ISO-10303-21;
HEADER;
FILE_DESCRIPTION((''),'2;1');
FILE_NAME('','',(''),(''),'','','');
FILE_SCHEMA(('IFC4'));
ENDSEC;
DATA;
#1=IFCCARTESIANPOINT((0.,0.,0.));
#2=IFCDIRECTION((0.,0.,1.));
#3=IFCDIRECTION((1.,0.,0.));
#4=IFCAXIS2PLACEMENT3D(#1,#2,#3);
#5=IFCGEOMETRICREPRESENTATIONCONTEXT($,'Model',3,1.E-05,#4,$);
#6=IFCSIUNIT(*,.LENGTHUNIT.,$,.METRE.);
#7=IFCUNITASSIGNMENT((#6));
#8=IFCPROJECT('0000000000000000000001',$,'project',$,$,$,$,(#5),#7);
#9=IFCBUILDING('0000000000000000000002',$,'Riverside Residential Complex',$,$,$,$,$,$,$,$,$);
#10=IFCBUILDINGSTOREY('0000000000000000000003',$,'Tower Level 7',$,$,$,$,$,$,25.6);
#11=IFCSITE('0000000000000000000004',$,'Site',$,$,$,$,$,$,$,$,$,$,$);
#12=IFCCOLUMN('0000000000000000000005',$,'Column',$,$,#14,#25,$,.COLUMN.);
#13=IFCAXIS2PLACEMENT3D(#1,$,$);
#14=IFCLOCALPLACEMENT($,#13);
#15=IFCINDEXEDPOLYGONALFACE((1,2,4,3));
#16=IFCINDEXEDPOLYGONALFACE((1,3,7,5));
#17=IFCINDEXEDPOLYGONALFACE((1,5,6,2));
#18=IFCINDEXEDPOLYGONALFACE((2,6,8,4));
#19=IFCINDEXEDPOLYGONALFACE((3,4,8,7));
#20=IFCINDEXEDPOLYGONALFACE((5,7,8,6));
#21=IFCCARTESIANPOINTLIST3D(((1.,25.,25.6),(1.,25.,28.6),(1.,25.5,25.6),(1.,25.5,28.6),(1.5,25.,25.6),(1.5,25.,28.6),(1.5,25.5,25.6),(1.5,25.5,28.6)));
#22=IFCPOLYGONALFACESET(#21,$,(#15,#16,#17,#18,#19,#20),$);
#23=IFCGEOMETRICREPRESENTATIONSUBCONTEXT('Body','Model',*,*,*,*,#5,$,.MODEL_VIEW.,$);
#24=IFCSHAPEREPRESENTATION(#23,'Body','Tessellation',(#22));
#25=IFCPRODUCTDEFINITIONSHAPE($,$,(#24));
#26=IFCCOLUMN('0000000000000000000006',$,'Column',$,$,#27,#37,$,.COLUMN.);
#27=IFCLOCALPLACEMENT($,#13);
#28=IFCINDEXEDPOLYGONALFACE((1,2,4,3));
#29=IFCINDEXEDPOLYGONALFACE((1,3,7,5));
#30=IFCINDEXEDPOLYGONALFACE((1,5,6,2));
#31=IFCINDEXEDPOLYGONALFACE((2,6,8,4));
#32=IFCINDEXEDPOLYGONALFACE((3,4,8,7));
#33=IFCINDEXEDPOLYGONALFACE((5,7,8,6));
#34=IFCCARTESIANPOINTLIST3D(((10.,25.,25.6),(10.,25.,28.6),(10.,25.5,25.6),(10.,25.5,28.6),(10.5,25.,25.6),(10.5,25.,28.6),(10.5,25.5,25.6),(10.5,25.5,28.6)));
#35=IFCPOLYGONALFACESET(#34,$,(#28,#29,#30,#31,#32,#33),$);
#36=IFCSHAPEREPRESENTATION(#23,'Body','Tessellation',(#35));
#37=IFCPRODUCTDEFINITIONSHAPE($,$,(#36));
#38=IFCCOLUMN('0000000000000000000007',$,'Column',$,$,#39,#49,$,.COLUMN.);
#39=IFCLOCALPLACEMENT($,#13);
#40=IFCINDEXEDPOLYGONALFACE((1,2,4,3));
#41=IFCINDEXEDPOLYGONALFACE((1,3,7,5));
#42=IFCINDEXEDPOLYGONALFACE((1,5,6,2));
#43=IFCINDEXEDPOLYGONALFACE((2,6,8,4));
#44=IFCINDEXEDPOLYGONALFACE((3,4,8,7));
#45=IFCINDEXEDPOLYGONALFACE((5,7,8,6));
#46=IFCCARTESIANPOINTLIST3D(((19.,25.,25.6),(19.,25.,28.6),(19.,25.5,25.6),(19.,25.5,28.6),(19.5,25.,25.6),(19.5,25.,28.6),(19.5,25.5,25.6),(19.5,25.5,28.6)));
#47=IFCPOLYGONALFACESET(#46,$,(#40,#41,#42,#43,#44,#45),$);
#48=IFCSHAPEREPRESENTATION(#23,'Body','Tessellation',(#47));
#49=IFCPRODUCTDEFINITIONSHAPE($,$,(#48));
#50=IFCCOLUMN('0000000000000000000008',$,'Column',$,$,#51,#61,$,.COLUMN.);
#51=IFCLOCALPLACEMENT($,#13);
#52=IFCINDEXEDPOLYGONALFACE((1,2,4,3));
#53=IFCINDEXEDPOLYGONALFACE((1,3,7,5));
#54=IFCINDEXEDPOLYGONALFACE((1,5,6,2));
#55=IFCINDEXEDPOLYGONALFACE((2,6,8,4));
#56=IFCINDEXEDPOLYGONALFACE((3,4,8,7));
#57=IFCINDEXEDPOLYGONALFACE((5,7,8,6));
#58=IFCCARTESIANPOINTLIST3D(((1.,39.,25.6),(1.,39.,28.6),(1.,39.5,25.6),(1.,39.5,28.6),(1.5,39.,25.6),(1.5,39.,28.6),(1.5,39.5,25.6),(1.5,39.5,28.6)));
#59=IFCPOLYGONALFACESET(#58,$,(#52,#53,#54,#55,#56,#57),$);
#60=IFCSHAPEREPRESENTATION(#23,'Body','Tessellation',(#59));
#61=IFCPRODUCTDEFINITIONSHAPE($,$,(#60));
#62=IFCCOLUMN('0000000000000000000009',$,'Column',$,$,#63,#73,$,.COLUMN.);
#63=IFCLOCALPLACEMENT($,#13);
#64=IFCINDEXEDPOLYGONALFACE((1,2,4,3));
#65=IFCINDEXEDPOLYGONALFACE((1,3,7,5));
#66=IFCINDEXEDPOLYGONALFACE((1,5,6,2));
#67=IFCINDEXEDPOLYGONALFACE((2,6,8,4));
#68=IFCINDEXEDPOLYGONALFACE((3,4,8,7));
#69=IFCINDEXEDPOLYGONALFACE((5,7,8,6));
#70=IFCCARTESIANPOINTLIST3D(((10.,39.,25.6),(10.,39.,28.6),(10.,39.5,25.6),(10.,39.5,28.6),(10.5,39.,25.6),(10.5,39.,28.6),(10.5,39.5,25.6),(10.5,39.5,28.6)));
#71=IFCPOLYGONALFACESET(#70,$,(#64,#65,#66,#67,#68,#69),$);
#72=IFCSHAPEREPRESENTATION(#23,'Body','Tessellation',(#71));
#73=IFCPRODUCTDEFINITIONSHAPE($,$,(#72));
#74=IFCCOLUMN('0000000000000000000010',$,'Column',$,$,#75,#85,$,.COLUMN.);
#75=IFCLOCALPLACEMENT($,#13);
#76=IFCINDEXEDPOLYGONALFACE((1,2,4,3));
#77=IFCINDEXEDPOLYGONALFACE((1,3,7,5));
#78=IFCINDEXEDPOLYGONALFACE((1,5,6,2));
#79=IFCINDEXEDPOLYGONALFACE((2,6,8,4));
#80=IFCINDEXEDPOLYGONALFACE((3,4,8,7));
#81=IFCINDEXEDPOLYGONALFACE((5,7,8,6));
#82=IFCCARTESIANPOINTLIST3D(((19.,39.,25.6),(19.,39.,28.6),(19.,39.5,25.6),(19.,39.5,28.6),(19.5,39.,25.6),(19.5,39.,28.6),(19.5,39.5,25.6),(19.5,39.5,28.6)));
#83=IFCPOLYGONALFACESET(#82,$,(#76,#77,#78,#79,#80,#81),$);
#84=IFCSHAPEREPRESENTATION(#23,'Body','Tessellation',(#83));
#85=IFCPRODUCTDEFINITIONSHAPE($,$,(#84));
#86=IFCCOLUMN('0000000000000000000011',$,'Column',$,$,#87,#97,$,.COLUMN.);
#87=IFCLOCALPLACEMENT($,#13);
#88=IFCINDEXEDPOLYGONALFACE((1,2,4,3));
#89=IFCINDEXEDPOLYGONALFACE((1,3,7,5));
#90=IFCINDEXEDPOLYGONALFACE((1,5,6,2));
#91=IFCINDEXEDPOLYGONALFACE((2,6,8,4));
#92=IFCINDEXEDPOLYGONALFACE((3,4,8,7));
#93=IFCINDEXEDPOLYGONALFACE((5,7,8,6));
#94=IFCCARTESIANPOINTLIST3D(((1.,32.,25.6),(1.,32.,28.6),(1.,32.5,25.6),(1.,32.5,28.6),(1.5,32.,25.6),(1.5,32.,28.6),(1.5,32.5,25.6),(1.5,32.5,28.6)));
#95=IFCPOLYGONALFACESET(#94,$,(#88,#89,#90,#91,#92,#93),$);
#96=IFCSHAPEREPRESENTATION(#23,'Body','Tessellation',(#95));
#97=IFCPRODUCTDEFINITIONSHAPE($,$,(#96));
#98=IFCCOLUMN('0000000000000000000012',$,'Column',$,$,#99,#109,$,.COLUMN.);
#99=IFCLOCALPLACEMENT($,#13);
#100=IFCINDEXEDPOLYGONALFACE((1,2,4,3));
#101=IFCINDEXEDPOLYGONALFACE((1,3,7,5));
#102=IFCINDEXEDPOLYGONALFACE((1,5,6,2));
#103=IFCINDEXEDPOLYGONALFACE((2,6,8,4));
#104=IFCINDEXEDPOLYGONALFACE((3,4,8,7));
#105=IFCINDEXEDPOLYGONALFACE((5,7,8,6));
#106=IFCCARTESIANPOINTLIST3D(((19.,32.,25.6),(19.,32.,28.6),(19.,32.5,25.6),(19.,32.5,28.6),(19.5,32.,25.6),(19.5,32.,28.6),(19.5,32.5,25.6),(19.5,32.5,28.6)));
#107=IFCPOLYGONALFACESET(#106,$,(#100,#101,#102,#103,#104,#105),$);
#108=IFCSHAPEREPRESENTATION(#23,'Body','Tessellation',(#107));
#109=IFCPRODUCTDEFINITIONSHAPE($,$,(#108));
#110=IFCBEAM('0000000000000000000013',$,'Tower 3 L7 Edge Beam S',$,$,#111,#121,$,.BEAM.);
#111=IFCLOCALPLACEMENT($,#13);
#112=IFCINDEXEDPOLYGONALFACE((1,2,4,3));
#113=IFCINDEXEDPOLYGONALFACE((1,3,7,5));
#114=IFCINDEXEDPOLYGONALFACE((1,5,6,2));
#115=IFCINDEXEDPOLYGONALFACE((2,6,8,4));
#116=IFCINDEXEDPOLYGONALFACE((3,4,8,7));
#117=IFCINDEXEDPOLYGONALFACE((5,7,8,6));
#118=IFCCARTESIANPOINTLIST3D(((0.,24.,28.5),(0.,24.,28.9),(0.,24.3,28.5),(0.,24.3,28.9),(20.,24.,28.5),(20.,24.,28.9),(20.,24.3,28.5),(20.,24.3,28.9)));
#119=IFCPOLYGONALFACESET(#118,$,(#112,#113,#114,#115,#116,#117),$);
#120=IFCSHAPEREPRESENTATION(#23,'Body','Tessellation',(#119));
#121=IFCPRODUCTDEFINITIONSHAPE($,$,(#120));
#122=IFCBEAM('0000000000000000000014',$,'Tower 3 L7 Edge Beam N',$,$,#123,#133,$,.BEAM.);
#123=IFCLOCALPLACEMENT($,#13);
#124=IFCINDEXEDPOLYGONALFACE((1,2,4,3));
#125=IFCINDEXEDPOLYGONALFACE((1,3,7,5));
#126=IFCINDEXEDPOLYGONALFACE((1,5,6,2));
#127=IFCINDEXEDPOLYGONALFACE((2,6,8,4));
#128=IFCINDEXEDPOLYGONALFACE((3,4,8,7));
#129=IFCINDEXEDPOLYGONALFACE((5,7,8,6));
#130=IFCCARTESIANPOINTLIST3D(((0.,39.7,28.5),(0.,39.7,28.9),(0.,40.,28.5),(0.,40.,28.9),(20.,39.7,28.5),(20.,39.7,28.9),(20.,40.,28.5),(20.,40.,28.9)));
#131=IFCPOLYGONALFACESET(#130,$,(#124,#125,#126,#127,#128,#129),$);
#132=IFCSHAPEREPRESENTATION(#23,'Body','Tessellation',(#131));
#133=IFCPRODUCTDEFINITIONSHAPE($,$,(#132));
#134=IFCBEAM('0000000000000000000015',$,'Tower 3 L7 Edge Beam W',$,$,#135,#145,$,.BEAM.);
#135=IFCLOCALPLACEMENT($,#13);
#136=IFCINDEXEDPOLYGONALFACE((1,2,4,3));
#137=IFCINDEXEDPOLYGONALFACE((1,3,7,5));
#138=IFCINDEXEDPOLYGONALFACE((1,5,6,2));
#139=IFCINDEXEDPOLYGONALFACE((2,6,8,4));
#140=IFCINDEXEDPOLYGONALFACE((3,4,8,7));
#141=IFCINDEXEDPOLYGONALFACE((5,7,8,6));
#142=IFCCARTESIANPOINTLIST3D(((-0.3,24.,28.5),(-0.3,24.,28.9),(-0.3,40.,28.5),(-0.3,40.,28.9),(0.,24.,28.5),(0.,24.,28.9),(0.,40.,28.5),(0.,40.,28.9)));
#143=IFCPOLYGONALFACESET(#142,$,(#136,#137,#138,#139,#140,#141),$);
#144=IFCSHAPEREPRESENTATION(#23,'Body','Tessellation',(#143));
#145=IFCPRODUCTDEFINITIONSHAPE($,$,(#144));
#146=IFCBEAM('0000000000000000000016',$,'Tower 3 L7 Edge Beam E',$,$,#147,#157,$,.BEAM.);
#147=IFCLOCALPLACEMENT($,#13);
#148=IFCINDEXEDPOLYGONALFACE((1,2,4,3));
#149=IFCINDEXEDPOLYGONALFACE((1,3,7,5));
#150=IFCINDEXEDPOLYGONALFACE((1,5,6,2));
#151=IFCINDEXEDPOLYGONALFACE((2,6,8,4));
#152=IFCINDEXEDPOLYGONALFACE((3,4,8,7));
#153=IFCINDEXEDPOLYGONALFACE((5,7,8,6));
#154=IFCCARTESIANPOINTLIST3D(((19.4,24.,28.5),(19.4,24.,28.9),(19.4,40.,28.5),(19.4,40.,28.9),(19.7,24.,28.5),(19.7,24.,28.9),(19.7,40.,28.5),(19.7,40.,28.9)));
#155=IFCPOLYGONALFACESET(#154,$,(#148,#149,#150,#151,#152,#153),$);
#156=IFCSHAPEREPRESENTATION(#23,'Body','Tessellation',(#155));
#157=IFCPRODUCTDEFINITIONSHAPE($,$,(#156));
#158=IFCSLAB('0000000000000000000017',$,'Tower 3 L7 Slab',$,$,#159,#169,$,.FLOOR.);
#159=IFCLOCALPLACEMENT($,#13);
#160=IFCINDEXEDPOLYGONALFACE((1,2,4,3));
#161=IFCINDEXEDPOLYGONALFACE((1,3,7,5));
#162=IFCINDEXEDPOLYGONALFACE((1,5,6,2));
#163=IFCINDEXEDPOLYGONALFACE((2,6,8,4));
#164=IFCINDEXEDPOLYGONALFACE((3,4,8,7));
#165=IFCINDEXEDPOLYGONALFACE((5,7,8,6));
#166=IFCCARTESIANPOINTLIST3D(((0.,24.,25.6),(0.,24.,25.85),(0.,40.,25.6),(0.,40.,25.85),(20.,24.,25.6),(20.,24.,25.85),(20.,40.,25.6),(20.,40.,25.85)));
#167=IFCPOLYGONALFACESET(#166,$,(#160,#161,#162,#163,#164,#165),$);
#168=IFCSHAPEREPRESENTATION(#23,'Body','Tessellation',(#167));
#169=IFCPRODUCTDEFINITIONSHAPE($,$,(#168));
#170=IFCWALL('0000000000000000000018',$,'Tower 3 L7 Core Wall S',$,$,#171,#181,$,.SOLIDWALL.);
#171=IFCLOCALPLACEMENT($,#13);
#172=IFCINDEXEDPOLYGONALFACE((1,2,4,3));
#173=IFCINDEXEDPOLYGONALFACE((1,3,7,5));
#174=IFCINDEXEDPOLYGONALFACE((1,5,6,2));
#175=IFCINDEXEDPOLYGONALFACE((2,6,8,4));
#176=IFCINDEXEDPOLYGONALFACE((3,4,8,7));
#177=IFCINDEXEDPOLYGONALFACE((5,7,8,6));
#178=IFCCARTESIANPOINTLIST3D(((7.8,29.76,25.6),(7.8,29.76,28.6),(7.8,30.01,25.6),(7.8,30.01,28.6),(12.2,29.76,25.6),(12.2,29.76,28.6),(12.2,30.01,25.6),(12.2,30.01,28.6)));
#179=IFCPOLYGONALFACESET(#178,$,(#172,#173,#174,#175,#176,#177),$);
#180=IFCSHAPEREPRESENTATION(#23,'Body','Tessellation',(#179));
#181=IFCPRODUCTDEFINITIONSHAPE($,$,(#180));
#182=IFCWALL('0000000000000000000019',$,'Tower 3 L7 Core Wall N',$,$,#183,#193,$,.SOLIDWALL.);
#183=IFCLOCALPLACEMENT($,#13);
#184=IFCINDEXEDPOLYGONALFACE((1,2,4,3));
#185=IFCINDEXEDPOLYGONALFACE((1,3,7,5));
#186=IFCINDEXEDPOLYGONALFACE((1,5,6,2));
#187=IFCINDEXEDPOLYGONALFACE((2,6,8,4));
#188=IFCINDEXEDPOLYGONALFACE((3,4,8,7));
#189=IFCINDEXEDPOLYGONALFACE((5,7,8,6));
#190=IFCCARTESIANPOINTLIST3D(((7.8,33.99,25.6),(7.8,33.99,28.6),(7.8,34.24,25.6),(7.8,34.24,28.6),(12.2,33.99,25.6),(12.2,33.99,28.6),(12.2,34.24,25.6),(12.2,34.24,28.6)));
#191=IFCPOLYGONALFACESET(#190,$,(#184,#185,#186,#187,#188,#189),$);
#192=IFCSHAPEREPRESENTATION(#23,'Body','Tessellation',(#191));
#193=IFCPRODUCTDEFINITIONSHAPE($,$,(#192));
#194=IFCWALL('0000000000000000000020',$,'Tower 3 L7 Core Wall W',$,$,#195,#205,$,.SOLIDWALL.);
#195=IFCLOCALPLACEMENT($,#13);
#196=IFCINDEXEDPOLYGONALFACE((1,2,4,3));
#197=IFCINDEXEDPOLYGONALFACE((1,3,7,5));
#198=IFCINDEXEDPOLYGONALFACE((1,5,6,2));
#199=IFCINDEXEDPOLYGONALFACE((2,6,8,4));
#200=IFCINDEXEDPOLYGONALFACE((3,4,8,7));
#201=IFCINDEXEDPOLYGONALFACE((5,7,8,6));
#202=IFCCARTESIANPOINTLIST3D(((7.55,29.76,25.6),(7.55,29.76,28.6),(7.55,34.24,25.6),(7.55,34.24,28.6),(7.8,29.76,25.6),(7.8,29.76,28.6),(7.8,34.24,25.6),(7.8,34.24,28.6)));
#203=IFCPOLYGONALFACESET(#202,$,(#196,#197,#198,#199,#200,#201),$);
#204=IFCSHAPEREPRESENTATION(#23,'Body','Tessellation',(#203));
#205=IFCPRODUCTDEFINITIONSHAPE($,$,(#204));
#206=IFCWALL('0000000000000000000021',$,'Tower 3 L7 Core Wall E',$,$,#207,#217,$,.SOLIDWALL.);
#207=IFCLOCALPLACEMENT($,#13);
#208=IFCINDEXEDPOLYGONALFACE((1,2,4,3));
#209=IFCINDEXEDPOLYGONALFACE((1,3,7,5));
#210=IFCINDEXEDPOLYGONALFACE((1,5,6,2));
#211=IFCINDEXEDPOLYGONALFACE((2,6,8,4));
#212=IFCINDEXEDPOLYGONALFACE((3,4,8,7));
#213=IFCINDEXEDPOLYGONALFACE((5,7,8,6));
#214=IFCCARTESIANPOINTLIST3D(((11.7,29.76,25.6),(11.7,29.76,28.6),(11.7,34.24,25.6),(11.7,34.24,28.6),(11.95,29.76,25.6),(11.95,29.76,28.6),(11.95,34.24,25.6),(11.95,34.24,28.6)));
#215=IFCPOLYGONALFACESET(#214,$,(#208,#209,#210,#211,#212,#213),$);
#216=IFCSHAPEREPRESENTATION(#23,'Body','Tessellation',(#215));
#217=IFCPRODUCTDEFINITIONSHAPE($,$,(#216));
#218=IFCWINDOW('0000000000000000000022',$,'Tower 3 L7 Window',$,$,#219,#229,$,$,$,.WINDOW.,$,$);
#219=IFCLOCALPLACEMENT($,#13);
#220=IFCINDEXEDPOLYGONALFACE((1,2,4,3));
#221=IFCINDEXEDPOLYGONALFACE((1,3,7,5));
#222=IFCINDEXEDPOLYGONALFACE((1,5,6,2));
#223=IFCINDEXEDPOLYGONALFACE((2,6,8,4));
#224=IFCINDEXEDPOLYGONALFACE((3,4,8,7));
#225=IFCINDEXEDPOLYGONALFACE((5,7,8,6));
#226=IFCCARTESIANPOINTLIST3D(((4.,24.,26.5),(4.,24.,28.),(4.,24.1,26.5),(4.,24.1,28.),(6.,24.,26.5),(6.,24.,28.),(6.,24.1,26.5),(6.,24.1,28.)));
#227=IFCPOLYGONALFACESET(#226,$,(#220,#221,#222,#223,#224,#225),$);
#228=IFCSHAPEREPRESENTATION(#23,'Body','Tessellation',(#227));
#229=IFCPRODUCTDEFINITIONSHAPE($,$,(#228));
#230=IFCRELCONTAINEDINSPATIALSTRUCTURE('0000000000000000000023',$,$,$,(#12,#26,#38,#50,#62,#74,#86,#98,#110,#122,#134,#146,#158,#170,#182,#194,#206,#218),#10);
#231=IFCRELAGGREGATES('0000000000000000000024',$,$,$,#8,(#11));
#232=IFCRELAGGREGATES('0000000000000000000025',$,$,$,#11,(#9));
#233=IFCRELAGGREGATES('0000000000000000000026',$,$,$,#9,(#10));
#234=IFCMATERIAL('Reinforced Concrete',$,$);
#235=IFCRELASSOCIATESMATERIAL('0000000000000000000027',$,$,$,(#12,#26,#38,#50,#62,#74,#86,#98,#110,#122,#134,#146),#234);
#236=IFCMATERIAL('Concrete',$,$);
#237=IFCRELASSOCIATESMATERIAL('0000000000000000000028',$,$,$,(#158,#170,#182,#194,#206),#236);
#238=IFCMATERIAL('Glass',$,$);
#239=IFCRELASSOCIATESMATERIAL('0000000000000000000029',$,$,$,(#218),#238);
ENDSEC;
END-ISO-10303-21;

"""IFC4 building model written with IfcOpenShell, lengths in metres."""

from ifc_helpers import new_model, si_unit, frame, origin_with_axes, place, context, subcontext, project, spatial, line, indexed_curve, outline, extrude, material, element, save


model = new_model("IFC4")

# Units and contexts
model_context = context("Model", 3, precision=1e-05, world=origin_with_axes())
body_context = subcontext(model_context, "Body", "Model", "MODEL_VIEW")
ifc_project = project(units=[si_unit("LENGTHUNIT", "METRE")], contexts=[model_context])

# Site, building, storey
site = spatial("IfcSite", under=ifc_project, Name="Site")
building = spatial("IfcBuilding", under=site, Name="Riverside Residential Complex")
storey = spatial("IfcBuildingStorey", under=building, Name="Tower Level 7", Elevation=25.6)

# Columns
ifc_material_1 = material(Name="Reinforced Concrete")
for number, where, z_axis, x_axis, name in (
    (1, (1.0, 25.0, 25.6), (0.0, 0.0, 1.0), (1.0, 0.0, 0.0), "Column"),
    (2, (10.0, 25.0, 25.6), (0.0, 0.0, 1.0), (1.0, 0.0, 0.0), "Column"),
    (3, (19.0, 25.0, 25.6), (0.0, 0.0, 1.0), (1.0, 0.0, 0.0), "Column"),
    (4, (1.0, 39.0, 25.6), (0.0, 0.0, 1.0), (1.0, 0.0, 0.0), "Column"),
    (5, (10.0, 39.0, 25.6), (0.0, 0.0, 1.0), (1.0, 0.0, 0.0), "Column"),
    (6, (19.0, 39.0, 25.6), (0.0, 0.0, 1.0), (1.0, 0.0, 0.0), "Column"),
    (7, (1.0, 32.0, 25.6), (0.0, 0.0, 1.0), (1.0, 0.0, 0.0), "Column"),
    (8, (19.0, 32.0, 25.6), (0.0, 0.0, 1.0), (1.0, 0.0, 0.0), "Column"),
):
    element("IfcColumn", number, at=place(None, frame(where, z_axis=z_axis, x_axis=x_axis)), inside=storey, material=ifc_material_1, Name=name, PredefinedType="COLUMN", context=body_context, shape_type="SweptSolid", body=[
        extrude(outline(indexed_curve([(0.0, 0.0), (0.5, 0.0), (0.5, 0.5), (0.0, 0.5)], segments=[line(1, 2, 3, 4, 1)])), origin_with_axes(), (0.0, 0.0, 1.0), 3.0),
    ])

# Beams
for number, where, z_axis, x_axis, name in (
    (9, (0.0, 24.0, 28.5), (0.0, 0.0, 1.0), (1.0, 0.0, 0.0), "Tower 3 L7 Edge Beam S"),
    (10, (0.0, 39.7, 28.5), (0.0, 0.0, 1.0), (1.0, 0.0, 0.0), "Tower 3 L7 Edge Beam N"),
):
    element("IfcBeam", number, at=place(None, frame(where, z_axis=z_axis, x_axis=x_axis)), inside=storey, material=ifc_material_1, Name=name, PredefinedType="BEAM", context=body_context, shape_type="SweptSolid", body=[
        extrude(outline(indexed_curve([(0.0, 0.0), (20.0, 0.0), (20.0, 0.3), (0.0, 0.3)], segments=[line(1, 2, 3, 4, 1)])), origin_with_axes(), (0.0, 0.0, 1.0), 0.4),
    ])
for number, where, z_axis, x_axis, name in (
    (11, (0.0, 24.0, 28.5), (0.0, 0.0, 1.0), (0.0, 1.0, 0.0), "Tower 3 L7 Edge Beam W"),
    (12, (19.7, 24.0, 28.5), (0.0, 0.0, 1.0), (0.0, 1.0, 0.0), "Tower 3 L7 Edge Beam E"),
):
    element("IfcBeam", number, at=place(None, frame(where, z_axis=z_axis, x_axis=x_axis)), inside=storey, material=ifc_material_1, Name=name, PredefinedType="BEAM", context=body_context, shape_type="SweptSolid", body=[
        extrude(outline(indexed_curve([(0.0, 0.0), (16.0, 0.0), (16.0, 0.3), (0.0, 0.3)], segments=[line(1, 2, 3, 4, 1)])), origin_with_axes(), (0.0, 0.0, 1.0), 0.4),
    ])

# Slab
ifc_material_2 = material(Name="Concrete")
slab_placement = place(None, frame((0.0, 24.0, 25.6), z_axis=(0.0, 0.0, 1.0), x_axis=(1.0, 0.0, 0.0)))
element("IfcSlab", 13, at=slab_placement, inside=storey, material=ifc_material_2, Name="Tower 3 L7 Slab", PredefinedType="FLOOR", context=body_context, shape_type="SweptSolid", body=[
    extrude(outline(indexed_curve([(0.0, 0.0), (20.0, 0.0), (20.0, 16.0), (0.0, 16.0)], segments=[line(1, 2, 3, 4, 1)])), origin_with_axes(), (0.0, 0.0, 1.0), 0.25),
])

# Walls
for number, where, z_axis, x_axis, name in (
    (14, (7.8, 29.76, 25.6), (0.0, 0.0, 1.0), (1.0, 0.0, 0.0), "Tower 3 L7 Core Wall S"),
    (15, (7.8, 33.99, 25.6), (0.0, 0.0, 1.0), (1.0, 0.0, 0.0), "Tower 3 L7 Core Wall N"),
):
    element("IfcWall", number, at=place(None, frame(where, z_axis=z_axis, x_axis=x_axis)), inside=storey, material=ifc_material_2, Name=name, PredefinedType="SOLIDWALL", context=body_context, shape_type="SweptSolid", body=[
        extrude(outline(indexed_curve([(0.0, 0.0), (4.4, 0.0), (4.4, 0.25), (0.0, 0.25)], segments=[line(1, 2, 3, 4, 1)])), origin_with_axes(), (0.0, 0.0, 1.0), 3.0),
    ])
for number, where, z_axis, x_axis, name in (
    (16, (7.8, 29.76, 25.6), (0.0, 0.0, 1.0), (0.0, 1.0, 0.0), "Tower 3 L7 Core Wall W"),
    (17, (11.95, 29.76, 25.6), (0.0, 0.0, 1.0), (0.0, 1.0, 0.0), "Tower 3 L7 Core Wall E"),
):
    element("IfcWall", number, at=place(None, frame(where, z_axis=z_axis, x_axis=x_axis)), inside=storey, material=ifc_material_2, Name=name, PredefinedType="SOLIDWALL", context=body_context, shape_type="SweptSolid", body=[
        extrude(outline(indexed_curve([(0.0, 0.0), (4.48, 0.0), (4.48, 0.25), (0.0, 0.25)], segments=[line(1, 2, 3, 4, 1)])), origin_with_axes(), (0.0, 0.0, 1.0), 3.0),
    ])

# Window
ifc_material_3 = material(Name="Glass")
for number, where, z_axis, x_axis, name in (
    (18, (4.0, 24.0, 26.5), (0.0, 0.0, 1.0), (1.0, 0.0, 0.0), "Tower 3 L7 Window"),
):
    element("IfcWindow", number, at=place(None, frame(where, z_axis=z_axis, x_axis=x_axis)), inside=storey, material=ifc_material_3, Name=name, PredefinedType="WINDOW", context=body_context, shape_type="SweptSolid", body=[
        extrude(outline(indexed_curve([(0.0, 0.0), (2.0, 0.0), (2.0, 0.1), (0.0, 0.1)], segments=[line(1, 2, 3, 4, 1)])), origin_with_axes(), (0.0, 0.0, 1.0), 1.5),
    ])

save(model, "model.ifc")
